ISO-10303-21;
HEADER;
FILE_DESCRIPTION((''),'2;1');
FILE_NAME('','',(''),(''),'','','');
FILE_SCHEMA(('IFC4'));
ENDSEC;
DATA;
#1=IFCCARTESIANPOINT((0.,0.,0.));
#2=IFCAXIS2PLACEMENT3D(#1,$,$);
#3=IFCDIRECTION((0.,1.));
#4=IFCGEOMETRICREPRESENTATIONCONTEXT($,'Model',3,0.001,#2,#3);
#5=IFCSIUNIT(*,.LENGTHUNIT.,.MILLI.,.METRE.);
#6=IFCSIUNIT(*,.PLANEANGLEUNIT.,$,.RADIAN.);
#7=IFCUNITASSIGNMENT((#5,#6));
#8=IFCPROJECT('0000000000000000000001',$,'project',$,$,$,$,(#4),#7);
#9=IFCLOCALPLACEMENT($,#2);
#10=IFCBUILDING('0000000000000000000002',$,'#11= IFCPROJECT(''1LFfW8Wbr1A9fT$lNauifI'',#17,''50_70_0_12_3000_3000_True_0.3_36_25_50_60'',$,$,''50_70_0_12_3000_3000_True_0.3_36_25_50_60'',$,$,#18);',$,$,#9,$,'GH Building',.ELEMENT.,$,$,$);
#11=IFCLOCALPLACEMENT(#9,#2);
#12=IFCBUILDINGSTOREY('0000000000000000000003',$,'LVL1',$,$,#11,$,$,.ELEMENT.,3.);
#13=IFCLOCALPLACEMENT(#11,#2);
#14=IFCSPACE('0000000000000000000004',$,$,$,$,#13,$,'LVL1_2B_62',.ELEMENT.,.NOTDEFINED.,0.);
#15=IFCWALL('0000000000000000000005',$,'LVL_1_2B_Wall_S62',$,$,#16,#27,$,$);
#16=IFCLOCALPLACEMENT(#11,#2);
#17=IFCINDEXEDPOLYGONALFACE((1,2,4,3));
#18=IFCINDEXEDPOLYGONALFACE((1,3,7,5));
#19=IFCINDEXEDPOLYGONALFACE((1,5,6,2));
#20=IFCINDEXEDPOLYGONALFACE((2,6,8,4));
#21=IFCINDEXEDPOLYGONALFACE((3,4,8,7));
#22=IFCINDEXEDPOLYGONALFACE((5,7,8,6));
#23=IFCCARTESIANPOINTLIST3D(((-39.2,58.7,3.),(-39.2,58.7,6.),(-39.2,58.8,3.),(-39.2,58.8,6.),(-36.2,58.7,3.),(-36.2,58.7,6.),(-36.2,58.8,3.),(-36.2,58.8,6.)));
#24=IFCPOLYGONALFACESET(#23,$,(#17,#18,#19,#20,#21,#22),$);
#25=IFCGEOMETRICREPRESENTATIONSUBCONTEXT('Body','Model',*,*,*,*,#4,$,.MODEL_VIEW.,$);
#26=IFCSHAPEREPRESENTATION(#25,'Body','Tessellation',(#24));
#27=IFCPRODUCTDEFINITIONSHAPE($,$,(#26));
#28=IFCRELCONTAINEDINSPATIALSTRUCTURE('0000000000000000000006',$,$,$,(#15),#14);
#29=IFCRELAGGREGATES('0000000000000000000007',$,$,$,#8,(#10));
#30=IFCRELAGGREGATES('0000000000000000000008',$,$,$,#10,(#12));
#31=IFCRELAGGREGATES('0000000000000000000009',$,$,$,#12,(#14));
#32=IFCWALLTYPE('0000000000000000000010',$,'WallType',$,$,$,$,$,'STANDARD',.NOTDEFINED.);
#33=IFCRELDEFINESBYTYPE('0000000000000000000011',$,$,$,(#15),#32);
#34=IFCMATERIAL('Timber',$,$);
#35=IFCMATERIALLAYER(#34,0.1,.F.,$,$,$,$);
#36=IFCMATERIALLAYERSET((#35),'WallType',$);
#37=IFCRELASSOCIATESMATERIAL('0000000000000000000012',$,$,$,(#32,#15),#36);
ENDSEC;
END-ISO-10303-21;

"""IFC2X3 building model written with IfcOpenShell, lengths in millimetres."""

from ifc_helpers import new_model, si_unit, direction, frame, frame_2d, origin, place, context, subcontext, project, spatial, rectangle, extrude, material, layer, layer_set, layer_usage, type_object, element, save


model = new_model("IFC2X3")

# Units and contexts
model_context = context("Model", 3, precision=0.001, world=origin(), true_north=direction((0.0, 1.0)))
body_context = subcontext(model_context, "Body", "Model", "MODEL_VIEW")
ifc_project = project(units=[si_unit("LENGTHUNIT", "METRE", prefix="MILLI"), si_unit("PLANEANGLEUNIT", "RADIAN")], contexts=[model_context])

# Building, storey
building_placement = place(None, origin())
building = spatial("IfcBuilding", under=ifc_project, at=building_placement, Name="#11= IFCPROJECT('1LFfW8Wbr1A9fT$lNauifI',#17,'50_70_0_12_3000_3000_True_0.3_36_25_50_60',$,$,'50_70_0_12_3000_3000_True_0.3_36_25_50_60',$,$,#18);", LongName="GH Building", CompositionType="ELEMENT")
storey_placement = place(building_placement, origin())
storey = spatial("IfcBuildingStorey", under=building, at=storey_placement, Name="LVL1", CompositionType="ELEMENT", Elevation=3.0)

# Shared definitions
space_1_placement = place(storey_placement, origin())
space_1 = spatial("IfcSpace", under=storey, at=space_1_placement, LongName="LVL1_2B_62", CompositionType="ELEMENT", InteriorOrExteriorSpace="NOTDEFINED", ElevationWithFlooring=0.0)

# Wall
ifc_material_1 = material(Name="Timber")
ifc_layer_1 = layer(ifc_material_1, 0.1, ventilated=False)
ifc_layer_set_1 = layer_set([ifc_layer_1], Name="WallType")
ifc_layer_usage_1 = layer_usage(ifc_layer_set_1, "AXIS2", "NEGATIVE", 0.0)
wall_type_1 = type_object("IfcWallType", Name="WallType", ElementType="STANDARD", PredefinedType="NOTDEFINED", material=ifc_layer_set_1)
wall_1_placement = place(space_1_placement, frame((-39.2, 58.8, 3.0)))
element("IfcWall", 1, at=wall_1_placement, inside=space_1, type_object=wall_type_1, material=ifc_layer_usage_1, Name="LVL_1_2B_Wall_S62", context=body_context, shape_type="SweptSolid", body=[
    extrude(rectangle(XDim=3.0, YDim=0.1, at=frame_2d((1.5, -0.1))), origin(), (0.0, 0.0, 1.0), 3.0),
])

save(model, "model.ifc")
